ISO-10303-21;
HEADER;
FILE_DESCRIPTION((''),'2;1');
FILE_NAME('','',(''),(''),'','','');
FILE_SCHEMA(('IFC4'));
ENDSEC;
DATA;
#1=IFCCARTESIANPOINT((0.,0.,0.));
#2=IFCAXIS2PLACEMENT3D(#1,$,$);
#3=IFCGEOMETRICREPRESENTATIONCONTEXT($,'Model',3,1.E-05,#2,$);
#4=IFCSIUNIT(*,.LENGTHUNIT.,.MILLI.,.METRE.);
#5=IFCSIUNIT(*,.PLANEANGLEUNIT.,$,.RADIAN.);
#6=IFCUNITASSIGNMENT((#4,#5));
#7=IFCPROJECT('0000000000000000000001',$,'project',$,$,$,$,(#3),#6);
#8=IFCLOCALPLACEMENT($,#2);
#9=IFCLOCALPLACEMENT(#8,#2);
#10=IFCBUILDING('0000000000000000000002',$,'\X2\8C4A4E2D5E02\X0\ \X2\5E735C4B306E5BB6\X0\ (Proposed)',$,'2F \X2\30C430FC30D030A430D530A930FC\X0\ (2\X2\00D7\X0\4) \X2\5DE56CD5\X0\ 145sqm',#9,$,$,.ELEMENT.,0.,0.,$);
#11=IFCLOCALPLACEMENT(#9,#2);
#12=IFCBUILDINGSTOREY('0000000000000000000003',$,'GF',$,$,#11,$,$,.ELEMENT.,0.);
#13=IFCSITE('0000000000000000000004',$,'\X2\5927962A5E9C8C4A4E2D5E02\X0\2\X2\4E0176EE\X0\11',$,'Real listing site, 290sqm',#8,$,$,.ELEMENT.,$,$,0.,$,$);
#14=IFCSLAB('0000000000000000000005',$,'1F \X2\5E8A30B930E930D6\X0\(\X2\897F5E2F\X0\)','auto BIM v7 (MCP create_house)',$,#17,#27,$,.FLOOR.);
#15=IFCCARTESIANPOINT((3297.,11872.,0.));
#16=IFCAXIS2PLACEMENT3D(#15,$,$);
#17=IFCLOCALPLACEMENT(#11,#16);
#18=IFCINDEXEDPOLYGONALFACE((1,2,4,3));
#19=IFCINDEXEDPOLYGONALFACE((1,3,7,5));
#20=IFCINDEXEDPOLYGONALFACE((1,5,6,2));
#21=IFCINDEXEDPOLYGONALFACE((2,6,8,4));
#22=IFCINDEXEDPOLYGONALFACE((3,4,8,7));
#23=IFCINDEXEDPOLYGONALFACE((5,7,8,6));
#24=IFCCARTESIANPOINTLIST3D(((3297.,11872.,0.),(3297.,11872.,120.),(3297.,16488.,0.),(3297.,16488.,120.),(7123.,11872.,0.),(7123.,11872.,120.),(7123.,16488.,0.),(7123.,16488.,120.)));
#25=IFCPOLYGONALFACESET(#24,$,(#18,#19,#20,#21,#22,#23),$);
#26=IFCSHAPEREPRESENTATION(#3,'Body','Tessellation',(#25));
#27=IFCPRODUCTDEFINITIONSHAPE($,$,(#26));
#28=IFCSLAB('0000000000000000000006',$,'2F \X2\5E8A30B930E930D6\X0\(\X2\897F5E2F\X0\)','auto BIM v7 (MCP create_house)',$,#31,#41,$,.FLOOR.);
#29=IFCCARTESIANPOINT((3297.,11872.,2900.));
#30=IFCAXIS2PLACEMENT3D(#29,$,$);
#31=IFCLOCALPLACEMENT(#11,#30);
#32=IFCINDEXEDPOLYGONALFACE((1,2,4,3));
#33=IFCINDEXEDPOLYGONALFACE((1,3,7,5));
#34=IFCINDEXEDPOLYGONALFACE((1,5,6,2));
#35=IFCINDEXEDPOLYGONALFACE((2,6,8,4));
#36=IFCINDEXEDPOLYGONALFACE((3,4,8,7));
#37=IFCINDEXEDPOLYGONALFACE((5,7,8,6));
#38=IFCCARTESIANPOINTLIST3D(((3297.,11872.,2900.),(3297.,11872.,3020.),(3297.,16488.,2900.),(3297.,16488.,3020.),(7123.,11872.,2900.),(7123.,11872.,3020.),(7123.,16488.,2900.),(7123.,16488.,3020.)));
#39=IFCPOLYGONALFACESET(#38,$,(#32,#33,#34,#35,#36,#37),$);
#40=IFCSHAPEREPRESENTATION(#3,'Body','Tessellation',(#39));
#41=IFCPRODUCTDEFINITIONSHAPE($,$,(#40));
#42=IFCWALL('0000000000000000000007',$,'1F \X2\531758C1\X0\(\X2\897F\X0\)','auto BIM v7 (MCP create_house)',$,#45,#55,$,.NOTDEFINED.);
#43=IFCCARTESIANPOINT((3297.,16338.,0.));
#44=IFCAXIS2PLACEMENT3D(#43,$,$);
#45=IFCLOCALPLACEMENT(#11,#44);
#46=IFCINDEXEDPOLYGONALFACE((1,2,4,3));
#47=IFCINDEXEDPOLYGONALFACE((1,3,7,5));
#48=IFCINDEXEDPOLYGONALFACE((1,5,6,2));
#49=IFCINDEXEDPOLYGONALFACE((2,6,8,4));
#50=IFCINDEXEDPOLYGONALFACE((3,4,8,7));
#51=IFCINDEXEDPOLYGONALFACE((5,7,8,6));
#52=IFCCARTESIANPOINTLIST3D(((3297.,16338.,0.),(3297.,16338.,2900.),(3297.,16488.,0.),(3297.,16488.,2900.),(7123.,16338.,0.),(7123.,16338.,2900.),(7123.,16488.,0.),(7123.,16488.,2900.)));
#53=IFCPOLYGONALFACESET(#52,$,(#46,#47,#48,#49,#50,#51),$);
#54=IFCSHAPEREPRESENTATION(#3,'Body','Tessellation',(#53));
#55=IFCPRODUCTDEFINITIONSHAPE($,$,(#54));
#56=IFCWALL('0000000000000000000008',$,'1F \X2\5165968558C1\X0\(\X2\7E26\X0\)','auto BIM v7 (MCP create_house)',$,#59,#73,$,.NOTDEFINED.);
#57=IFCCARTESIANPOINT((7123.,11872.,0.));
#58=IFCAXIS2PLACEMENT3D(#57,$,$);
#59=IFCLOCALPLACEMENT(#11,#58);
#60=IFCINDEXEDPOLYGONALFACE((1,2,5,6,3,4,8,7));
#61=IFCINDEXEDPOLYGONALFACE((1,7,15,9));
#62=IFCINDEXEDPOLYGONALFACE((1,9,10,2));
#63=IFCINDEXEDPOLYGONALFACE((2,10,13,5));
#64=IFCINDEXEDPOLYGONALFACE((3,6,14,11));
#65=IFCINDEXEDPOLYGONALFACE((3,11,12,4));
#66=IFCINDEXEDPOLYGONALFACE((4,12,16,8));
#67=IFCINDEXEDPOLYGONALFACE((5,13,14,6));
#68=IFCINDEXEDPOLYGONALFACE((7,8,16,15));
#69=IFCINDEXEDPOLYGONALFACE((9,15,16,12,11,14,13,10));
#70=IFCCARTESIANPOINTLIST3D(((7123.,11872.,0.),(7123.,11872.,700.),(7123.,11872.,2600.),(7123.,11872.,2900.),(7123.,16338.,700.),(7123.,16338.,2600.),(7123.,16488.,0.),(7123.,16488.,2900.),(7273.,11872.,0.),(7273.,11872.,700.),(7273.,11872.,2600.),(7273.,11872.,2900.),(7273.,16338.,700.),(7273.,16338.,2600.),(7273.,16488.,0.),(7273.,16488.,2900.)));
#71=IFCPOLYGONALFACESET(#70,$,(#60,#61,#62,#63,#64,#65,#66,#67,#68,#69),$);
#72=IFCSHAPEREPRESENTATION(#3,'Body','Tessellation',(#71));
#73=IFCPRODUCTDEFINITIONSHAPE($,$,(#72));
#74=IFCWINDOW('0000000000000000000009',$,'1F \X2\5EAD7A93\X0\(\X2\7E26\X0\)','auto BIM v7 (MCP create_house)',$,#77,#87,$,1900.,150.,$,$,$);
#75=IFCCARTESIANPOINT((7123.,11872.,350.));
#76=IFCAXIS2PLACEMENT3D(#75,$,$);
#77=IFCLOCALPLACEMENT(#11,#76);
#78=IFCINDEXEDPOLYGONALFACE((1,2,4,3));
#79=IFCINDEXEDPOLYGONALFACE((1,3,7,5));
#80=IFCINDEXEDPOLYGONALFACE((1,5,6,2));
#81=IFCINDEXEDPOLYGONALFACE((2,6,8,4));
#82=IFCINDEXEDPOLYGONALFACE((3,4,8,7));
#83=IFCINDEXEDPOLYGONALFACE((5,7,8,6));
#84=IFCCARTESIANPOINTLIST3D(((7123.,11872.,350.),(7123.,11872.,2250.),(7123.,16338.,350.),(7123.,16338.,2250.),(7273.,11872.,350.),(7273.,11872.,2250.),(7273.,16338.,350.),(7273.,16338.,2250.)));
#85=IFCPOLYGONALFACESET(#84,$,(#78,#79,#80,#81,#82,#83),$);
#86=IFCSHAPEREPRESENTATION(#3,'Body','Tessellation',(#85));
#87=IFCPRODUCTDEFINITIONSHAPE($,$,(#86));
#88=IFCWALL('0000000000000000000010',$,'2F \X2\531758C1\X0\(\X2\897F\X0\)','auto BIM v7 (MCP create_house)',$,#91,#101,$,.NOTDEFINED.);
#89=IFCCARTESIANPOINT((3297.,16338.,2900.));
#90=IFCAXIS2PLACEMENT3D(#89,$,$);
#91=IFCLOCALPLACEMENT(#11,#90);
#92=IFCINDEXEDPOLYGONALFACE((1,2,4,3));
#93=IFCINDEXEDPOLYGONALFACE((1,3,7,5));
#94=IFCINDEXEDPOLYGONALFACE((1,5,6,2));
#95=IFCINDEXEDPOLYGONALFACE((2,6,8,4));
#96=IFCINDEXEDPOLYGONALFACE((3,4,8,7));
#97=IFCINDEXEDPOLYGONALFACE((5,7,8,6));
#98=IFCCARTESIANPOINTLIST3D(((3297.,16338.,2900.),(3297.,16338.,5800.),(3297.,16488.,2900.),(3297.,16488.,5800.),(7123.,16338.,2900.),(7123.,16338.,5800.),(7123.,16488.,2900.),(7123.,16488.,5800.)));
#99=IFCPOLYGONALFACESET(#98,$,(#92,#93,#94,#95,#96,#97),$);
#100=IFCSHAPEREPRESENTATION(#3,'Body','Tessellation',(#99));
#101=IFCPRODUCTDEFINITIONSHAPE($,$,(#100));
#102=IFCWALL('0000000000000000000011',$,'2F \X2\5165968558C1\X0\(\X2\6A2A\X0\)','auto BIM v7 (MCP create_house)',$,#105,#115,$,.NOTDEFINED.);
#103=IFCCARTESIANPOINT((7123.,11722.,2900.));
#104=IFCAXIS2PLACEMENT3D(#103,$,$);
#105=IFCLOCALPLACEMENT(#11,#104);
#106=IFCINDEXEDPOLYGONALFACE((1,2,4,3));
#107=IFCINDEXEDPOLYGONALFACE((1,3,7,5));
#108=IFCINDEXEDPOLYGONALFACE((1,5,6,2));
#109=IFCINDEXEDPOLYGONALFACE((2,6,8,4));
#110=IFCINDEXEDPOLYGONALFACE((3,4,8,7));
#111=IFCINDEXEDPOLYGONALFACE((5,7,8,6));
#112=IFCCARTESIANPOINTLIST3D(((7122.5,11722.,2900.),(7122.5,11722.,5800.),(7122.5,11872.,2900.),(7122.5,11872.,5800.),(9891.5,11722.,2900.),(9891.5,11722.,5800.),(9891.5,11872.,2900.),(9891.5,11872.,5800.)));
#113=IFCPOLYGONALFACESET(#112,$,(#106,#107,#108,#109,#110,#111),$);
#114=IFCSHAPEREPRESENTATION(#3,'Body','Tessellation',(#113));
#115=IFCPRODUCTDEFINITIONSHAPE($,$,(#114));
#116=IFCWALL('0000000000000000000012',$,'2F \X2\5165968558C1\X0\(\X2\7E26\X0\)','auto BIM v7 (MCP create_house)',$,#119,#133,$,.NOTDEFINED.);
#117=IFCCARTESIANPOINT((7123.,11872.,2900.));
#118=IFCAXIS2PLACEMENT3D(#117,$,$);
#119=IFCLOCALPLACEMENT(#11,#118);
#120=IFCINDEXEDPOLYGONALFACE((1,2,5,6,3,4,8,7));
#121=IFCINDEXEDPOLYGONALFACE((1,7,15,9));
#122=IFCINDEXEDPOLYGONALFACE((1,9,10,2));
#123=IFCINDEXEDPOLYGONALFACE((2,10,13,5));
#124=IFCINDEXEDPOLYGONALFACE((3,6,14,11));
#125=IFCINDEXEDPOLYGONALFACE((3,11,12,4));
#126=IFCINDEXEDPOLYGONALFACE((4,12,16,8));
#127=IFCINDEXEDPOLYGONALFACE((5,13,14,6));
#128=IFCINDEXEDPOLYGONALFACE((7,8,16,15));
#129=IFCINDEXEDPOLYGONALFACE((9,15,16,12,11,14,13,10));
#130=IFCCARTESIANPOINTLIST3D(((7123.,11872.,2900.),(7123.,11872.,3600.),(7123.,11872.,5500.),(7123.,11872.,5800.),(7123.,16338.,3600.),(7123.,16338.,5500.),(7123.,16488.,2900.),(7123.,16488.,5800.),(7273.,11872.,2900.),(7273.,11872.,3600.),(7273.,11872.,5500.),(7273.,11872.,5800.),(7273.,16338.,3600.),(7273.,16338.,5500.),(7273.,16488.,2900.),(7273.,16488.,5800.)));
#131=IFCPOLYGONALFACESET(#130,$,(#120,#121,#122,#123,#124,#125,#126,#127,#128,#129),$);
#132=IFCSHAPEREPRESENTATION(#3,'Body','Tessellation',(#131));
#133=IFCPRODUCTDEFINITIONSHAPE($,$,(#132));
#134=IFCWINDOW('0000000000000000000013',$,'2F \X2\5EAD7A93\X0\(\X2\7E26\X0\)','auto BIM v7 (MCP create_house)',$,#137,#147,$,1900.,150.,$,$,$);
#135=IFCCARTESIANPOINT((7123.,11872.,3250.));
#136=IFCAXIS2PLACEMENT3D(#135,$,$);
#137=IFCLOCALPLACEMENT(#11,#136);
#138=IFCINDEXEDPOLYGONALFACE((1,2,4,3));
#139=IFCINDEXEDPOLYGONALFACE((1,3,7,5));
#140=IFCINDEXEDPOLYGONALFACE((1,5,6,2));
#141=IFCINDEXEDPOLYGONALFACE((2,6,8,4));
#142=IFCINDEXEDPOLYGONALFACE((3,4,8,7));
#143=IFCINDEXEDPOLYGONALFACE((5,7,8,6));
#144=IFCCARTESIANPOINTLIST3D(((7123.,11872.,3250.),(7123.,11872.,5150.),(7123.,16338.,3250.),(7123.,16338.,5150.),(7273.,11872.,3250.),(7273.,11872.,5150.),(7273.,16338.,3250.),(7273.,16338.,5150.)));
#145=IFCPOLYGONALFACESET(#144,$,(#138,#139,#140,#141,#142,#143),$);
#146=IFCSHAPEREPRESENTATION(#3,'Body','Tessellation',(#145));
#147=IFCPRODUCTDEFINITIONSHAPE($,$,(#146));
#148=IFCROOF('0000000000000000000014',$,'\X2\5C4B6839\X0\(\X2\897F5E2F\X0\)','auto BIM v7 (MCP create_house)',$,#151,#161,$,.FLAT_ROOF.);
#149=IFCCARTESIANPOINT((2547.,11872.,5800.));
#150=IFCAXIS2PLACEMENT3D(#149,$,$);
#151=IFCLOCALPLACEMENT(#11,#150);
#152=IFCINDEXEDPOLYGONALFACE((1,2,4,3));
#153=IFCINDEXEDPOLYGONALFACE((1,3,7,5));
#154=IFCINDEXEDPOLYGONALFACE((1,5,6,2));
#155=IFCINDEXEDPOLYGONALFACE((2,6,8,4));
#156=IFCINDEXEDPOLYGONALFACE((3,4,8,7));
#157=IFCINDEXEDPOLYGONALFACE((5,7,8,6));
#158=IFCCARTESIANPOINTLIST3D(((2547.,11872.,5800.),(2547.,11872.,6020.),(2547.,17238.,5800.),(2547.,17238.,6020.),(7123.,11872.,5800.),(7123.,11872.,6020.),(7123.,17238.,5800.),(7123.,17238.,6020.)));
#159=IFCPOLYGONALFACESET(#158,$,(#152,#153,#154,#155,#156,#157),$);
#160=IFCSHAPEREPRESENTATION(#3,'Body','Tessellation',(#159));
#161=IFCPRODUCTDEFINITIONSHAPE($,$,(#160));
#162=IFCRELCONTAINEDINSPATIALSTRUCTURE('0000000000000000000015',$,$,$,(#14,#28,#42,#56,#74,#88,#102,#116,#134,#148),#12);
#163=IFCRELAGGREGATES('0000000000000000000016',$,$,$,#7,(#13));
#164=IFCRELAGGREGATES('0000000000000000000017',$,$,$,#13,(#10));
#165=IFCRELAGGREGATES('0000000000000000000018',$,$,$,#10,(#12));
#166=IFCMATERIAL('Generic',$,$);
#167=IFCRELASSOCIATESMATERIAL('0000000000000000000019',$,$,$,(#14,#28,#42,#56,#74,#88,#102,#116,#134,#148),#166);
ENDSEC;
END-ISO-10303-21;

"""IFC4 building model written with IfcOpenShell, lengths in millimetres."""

from ifc_helpers import new_model, si_unit, frame, frame_2d, origin, place, context, project, spatial, rectangle, extrude, material, element, fill, save


model = new_model("IFC4")

# Units and contexts
model_context = context("Model", 3, precision=1e-05, world=origin())
ifc_project = project(units=[si_unit("LENGTHUNIT", "METRE", prefix="MILLI"), si_unit("PLANEANGLEUNIT", "RADIAN")], contexts=[model_context])

# Site, building, storey
site_placement = place(None, origin())
site = spatial("IfcSite", under=ifc_project, at=site_placement, Name="大阪府豊中市2丁目11", ObjectType="Real listing site, 290sqm", CompositionType="ELEMENT", RefElevation=0.0)
building_placement = place(site_placement, origin())
building = spatial("IfcBuilding", under=site, at=building_placement, Name="豊中市 平屋の家 (Proposed)", ObjectType="2F ツーバイフォー (2×4) 工法 145sqm", CompositionType="ELEMENT", ElevationOfRefHeight=0.0, ElevationOfTerrain=0.0)
storey_placement = place(building_placement, origin())
storey = spatial("IfcBuildingStorey", under=building, at=storey_placement, Name="GF", CompositionType="ELEMENT", Elevation=0.0)

# Slabs
ifc_material = material(Name="Generic")
slab_1_placement = place(storey_placement, frame((3297.0, 11872.0, 0.0)))
element("IfcSlab", 1, at=slab_1_placement, inside=storey, material=ifc_material, Name="1F 床スラブ(西帯)", Description="auto BIM v7 (MCP create_house)", PredefinedType="FLOOR", context=model_context, shape_type="SweptSolid", body=[
    extrude(rectangle(XDim=3826.0, YDim=4616.0, at=frame_2d((1913.0, 2308.0))), frame((3297.0, 11872.0, 0.0)), (0.0, 0.0, 1.0), 120.0),
])
slab_2_placement = place(storey_placement, frame((3297.0, 11872.0, 2900.0)))
element("IfcSlab", 2, at=slab_2_placement, inside=storey, material=ifc_material, Name="2F 床スラブ(西帯)", Description="auto BIM v7 (MCP create_house)", PredefinedType="FLOOR", context=model_context, shape_type="SweptSolid", body=[
    extrude(rectangle(XDim=3826.0, YDim=4616.0, at=frame_2d((1913.0, 2308.0))), frame((3297.0, 11872.0, 2900.0)), (0.0, 0.0, 1.0), 120.0),
])

# Wall
wall_1_placement = place(storey_placement, frame((3297.0, 16338.0, 0.0)))
element("IfcWall", 3, at=wall_1_placement, inside=storey, material=ifc_material, Name="1F 北壁(西)", Description="auto BIM v7 (MCP create_house)", PredefinedType="NOTDEFINED", context=model_context, shape_type="SweptSolid", body=[
    extrude(rectangle(XDim=3826.0, YDim=150.0, at=frame_2d((1913.0, 75.0))), frame((3297.0, 16338.0, 0.0)), (0.0, 0.0, 1.0), 2900.0),
])

# Wall, opening, window
wall_2_placement = place(storey_placement, frame((7123.0, 11872.0, 0.0)))
wall_2 = element("IfcWall", 4, at=wall_2_placement, inside=storey, material=ifc_material, Name="1F 入隅壁(縦)", Description="auto BIM v7 (MCP create_house)", PredefinedType="NOTDEFINED", context=model_context, shape_type="SweptSolid", body=[
    extrude(rectangle(XDim=150.0, YDim=4616.0, at=frame_2d((75.0, 2308.0))), frame((7123.0, 11872.0, 0.0)), (0.0, 0.0, 1.0), 2900.0),
])
opening_1_placement = place(storey_placement, frame((7123.0, 11872.0, 350.0)))
opening_1 = element("IfcOpeningElement", 5, at=opening_1_placement, cuts=wall_2, PredefinedType="NOTDEFINED", context=model_context, shape_type="SweptSolid", body=[
    extrude(rectangle(XDim=150.0, YDim=4466.0, at=frame_2d((75.0, 2233.0))), frame((7123.0, 11872.0, 350.0)), (0.0, 0.0, 1.0), 1900.0),
])
window_1_placement = place(storey_placement, frame((7123.0, 11872.0, 350.0)))
window_1 = element("IfcWindow", 6, at=window_1_placement, inside=storey, material=ifc_material, Name="1F 庭窓(縦)", Description="auto BIM v7 (MCP create_house)", OverallHeight=1900.0, OverallWidth=150.0, context=model_context, shape_type="SweptSolid", body=[
    extrude(rectangle(XDim=150.0, YDim=4466.0, at=frame_2d((75.0, 2233.0))), frame((7123.0, 11872.0, 350.0)), (0.0, 0.0, 1.0), 1900.0),
])
fill(opening_1, window_1)

# Walls
wall_3_placement = place(storey_placement, frame((3297.0, 16338.0, 2900.0)))
element("IfcWall", 7, at=wall_3_placement, inside=storey, material=ifc_material, Name="2F 北壁(西)", Description="auto BIM v7 (MCP create_house)", PredefinedType="NOTDEFINED", context=model_context, shape_type="SweptSolid", body=[
    extrude(rectangle(XDim=3826.0, YDim=150.0, at=frame_2d((1913.0, 75.0))), frame((3297.0, 16338.0, 2900.0)), (0.0, 0.0, 1.0), 2900.0),
])
wall_4_placement = place(storey_placement, frame((7123.0, 11722.0, 2900.0)))
element("IfcWall", 8, at=wall_4_placement, inside=storey, material=ifc_material, Name="2F 入隅壁(横)", Description="auto BIM v7 (MCP create_house)", PredefinedType="NOTDEFINED", context=model_context, shape_type="SweptSolid", body=[
    extrude(rectangle(XDim=2769.0, YDim=150.0, at=frame_2d((1384.0, 75.0))), frame((7123.0, 11722.0, 2900.0)), (0.0, 0.0, 1.0), 2900.0),
])

# Wall, opening, window
wall_5_placement = place(storey_placement, frame((7123.0, 11872.0, 2900.0)))
wall_5 = element("IfcWall", 9, at=wall_5_placement, inside=storey, material=ifc_material, Name="2F 入隅壁(縦)", Description="auto BIM v7 (MCP create_house)", PredefinedType="NOTDEFINED", context=model_context, shape_type="SweptSolid", body=[
    extrude(rectangle(XDim=150.0, YDim=4616.0, at=frame_2d((75.0, 2308.0))), frame((7123.0, 11872.0, 2900.0)), (0.0, 0.0, 1.0), 2900.0),
])
opening_2_placement = place(storey_placement, frame((7123.0, 11872.0, 3250.0)))
opening_2 = element("IfcOpeningElement", 10, at=opening_2_placement, cuts=wall_5, PredefinedType="NOTDEFINED", context=model_context, shape_type="SweptSolid", body=[
    extrude(rectangle(XDim=150.0, YDim=4466.0, at=frame_2d((75.0, 2233.0))), frame((7123.0, 11872.0, 3250.0)), (0.0, 0.0, 1.0), 1900.0),
])
window_2_placement = place(storey_placement, frame((7123.0, 11872.0, 3250.0)))
window_2 = element("IfcWindow", 11, at=window_2_placement, inside=storey, material=ifc_material, Name="2F 庭窓(縦)", Description="auto BIM v7 (MCP create_house)", OverallHeight=1900.0, OverallWidth=150.0, context=model_context, shape_type="SweptSolid", body=[
    extrude(rectangle(XDim=150.0, YDim=4466.0, at=frame_2d((75.0, 2233.0))), frame((7123.0, 11872.0, 3250.0)), (0.0, 0.0, 1.0), 1900.0),
])
fill(opening_2, window_2)

# Roof
for number, where, name in (
    (12, (2547.0, 11872.0, 5800.0), "屋根(西帯)"),
):
    element("IfcRoof", number, at=place(storey_placement, frame(where)), inside=storey, material=ifc_material, Name=name, Description="auto BIM v7 (MCP create_house)", PredefinedType="FLAT_ROOF", context=model_context, shape_type="SweptSolid", body=[
        extrude(rectangle(XDim=4576.0, YDim=5366.0, at=frame_2d((2288.0, 2683.0))), frame((2547.0, 11872.0, 5800.0)), (0.0, 0.0, 1.0), 220.0),
    ])

save(model, "model.ifc")
